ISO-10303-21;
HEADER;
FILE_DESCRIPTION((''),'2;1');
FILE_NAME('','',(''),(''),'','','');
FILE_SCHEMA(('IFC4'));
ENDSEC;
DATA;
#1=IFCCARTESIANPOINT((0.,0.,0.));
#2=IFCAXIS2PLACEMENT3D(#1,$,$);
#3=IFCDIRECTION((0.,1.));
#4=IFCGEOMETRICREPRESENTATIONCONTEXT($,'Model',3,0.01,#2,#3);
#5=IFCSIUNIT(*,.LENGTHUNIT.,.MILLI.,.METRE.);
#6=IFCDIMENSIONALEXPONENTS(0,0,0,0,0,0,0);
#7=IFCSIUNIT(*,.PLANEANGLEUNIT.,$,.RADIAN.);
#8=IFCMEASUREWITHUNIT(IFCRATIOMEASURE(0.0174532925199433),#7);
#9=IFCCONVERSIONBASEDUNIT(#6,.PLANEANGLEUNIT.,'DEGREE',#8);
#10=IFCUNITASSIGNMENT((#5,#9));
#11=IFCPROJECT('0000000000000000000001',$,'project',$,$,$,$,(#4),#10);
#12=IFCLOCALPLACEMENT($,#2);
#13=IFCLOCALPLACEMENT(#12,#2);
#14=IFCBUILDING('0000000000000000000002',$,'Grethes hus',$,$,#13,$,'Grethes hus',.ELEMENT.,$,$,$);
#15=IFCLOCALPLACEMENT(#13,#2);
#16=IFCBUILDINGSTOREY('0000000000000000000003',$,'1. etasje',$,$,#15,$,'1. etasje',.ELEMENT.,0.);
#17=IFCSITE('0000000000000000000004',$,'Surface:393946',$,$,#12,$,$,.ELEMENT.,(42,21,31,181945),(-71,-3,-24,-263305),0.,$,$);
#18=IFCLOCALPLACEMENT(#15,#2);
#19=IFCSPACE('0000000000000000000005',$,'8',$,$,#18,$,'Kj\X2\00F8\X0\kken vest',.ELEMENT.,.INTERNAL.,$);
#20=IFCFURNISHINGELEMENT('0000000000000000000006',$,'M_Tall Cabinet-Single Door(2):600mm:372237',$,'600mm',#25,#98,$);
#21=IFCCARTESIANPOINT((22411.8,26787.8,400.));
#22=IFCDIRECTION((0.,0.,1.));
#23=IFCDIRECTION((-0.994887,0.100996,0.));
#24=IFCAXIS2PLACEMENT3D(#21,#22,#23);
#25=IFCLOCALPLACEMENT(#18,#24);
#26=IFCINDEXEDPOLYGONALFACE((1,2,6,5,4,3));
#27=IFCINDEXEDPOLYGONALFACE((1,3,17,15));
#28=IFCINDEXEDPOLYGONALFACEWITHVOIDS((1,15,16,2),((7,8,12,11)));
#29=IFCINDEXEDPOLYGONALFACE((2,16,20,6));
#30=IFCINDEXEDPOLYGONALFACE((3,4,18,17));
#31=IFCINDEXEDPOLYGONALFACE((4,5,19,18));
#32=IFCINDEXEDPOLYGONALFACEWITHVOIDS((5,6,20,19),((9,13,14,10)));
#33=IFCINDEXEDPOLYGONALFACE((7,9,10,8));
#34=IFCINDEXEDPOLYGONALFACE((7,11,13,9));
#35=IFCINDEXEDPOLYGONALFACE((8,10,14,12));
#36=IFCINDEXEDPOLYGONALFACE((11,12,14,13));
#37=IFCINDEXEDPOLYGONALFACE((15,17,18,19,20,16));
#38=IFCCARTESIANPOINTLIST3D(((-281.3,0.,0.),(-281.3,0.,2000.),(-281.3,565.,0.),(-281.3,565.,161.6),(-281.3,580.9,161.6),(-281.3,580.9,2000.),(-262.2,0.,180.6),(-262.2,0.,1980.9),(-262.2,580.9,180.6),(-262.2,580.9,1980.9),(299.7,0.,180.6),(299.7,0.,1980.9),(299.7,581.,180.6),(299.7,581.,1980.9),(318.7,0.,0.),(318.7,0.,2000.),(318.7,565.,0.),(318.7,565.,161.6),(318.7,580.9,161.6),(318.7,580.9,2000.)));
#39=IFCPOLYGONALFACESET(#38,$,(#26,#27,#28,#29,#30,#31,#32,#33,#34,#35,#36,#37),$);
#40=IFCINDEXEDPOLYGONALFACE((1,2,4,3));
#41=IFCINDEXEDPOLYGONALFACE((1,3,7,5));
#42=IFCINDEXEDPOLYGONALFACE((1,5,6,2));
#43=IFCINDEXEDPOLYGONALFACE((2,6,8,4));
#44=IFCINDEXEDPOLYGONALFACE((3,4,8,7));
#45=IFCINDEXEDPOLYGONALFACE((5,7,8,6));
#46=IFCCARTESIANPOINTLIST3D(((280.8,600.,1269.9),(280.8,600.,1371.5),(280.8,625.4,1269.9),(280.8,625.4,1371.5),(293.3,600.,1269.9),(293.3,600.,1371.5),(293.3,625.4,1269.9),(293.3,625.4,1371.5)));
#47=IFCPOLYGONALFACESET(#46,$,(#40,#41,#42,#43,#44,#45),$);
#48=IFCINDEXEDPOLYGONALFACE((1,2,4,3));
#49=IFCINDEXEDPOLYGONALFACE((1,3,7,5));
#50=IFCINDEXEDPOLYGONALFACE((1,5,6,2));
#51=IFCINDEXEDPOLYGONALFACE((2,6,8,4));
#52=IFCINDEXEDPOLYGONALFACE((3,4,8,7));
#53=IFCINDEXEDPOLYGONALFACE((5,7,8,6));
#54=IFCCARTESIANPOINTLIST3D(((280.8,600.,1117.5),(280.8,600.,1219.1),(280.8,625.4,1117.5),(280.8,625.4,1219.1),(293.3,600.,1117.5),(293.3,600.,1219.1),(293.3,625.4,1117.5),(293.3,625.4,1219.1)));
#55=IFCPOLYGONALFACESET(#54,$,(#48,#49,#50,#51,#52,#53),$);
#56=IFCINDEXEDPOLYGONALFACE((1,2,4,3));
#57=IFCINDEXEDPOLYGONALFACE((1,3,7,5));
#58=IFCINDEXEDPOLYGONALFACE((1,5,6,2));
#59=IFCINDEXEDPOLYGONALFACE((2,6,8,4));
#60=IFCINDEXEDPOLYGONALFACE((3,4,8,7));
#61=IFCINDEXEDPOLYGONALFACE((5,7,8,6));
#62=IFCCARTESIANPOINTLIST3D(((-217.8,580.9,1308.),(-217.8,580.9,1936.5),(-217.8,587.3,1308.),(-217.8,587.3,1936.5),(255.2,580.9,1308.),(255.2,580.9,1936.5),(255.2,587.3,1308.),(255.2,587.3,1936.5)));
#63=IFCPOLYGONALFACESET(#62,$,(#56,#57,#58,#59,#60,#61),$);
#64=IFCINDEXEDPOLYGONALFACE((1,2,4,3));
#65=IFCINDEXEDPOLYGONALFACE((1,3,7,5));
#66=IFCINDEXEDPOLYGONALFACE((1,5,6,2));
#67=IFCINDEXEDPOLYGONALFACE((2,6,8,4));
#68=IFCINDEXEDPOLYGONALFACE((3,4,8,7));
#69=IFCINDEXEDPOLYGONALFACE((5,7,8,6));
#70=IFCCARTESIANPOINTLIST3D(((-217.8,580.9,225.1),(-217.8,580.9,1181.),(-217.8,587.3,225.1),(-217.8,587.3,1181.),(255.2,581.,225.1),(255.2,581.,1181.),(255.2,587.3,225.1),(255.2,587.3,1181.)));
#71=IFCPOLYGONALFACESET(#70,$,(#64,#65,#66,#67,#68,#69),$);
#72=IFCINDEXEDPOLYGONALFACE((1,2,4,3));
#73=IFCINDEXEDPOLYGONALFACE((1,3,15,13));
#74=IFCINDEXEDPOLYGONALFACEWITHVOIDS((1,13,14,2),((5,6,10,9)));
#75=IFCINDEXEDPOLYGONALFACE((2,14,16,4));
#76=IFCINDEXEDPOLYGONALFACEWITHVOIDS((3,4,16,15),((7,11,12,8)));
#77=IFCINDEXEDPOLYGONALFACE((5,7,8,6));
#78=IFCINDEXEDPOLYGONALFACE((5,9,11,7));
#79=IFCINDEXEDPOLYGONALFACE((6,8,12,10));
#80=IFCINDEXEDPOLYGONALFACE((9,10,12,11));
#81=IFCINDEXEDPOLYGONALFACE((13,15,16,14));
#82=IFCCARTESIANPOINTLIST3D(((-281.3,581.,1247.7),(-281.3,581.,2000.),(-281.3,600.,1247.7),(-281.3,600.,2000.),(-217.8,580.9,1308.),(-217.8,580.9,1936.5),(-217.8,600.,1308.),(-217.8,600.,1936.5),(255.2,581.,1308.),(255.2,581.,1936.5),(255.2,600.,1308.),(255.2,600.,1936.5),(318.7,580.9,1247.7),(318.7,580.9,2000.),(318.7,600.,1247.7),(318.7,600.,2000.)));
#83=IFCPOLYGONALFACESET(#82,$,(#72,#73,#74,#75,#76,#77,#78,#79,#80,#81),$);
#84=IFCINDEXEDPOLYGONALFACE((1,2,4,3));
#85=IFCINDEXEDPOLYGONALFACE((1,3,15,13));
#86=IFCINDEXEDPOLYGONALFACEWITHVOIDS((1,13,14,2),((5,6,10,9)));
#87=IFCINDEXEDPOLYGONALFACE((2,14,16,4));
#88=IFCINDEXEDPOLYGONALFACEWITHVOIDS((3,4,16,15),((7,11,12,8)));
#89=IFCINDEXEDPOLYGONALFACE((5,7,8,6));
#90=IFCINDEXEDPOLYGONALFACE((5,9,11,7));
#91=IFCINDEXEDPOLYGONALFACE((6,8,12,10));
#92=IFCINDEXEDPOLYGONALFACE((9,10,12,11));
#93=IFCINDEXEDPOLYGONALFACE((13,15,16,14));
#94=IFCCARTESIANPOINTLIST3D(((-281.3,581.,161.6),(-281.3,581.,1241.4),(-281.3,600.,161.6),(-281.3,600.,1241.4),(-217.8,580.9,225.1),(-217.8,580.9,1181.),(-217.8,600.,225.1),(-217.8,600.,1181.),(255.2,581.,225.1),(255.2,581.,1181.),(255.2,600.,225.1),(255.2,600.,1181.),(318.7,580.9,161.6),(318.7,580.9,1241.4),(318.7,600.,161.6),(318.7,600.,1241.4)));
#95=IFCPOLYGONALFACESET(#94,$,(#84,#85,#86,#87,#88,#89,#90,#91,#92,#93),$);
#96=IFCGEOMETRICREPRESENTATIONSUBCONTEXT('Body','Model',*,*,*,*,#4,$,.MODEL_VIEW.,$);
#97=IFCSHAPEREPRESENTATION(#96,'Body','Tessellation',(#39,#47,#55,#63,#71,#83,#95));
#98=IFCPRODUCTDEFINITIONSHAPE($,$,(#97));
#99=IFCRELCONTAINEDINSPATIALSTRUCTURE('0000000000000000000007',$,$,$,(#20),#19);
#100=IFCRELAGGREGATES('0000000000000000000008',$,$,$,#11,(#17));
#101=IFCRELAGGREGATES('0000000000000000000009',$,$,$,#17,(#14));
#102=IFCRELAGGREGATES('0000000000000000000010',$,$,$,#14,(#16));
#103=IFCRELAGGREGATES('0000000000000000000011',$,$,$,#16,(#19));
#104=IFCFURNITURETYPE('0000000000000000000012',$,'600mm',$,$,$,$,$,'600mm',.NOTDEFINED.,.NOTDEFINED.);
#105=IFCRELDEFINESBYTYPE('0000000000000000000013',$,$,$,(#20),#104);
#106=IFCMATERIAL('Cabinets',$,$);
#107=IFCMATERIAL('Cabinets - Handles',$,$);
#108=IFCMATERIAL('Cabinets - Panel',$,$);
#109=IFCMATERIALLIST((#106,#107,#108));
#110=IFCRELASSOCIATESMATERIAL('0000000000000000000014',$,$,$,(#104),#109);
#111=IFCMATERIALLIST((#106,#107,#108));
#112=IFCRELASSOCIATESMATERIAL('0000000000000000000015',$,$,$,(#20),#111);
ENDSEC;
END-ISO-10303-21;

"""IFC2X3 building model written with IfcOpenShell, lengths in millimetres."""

from ifc_helpers import new_model, entity, si_unit, converted_unit, direction, frame, frame_2d, origin, origin_2d_with_axis, place, context, subcontext, project, spatial, polyline, rectangle, outline, extrude, source, transform, mapped, material, material_list, type_object, type_shapes, element, save


model = new_model("IFC2X3")

# Units and contexts
model_context = context("Model", 3, precision=0.01, world=origin(), true_north=direction((0.0, 1.0)))
body_context = subcontext(model_context, "Body", "Model", "MODEL_VIEW")
ifc_project = project(units=[si_unit("LENGTHUNIT", "METRE", prefix="MILLI"), converted_unit("PLANEANGLEUNIT", "DEGREE", entity("IfcRatioMeasure", 0.0174532925199433), si_unit("PLANEANGLEUNIT", "RADIAN"), dimensions=[0, 0, 0, 0, 0, 0, 0])], contexts=[model_context])

# Site, building, storey
site_placement = place(None, origin())
site = spatial("IfcSite", under=ifc_project, at=site_placement, Name="Surface:393946", CompositionType="ELEMENT", RefLatitude=(42, 21, 31, 181945), RefLongitude=(-71, -3, -24, -263305), RefElevation=0.0)
building_placement = place(site_placement, origin())
building = spatial("IfcBuilding", under=site, at=building_placement, Name="Grethes hus", LongName="Grethes hus", CompositionType="ELEMENT")
storey_placement = place(building_placement, origin())
storey = spatial("IfcBuildingStorey", under=building, at=storey_placement, Name="1. etasje", LongName="1. etasje", CompositionType="ELEMENT", Elevation=0.0)

# Shared definitions
space_placement = place(storey_placement, origin())
space = spatial("IfcSpace", under=storey, at=space_placement, Name="8", LongName="Kjøkken vest", CompositionType="ELEMENT", InteriorOrExteriorSpace="INTERNAL")

# Furnishing element, opening
ifc_material_1 = material(Name="Cabinets")
ifc_material_2 = material(Name="Cabinets - Handles")
ifc_material_3 = material(Name="Cabinets - Panel")
ifc_material_list_1 = material_list([ifc_material_1, ifc_material_2, ifc_material_3])
ifc_material_list_2 = material_list([ifc_material_1, ifc_material_2, ifc_material_3])
furniture_type_1 = type_object("IfcFurnitureType", Name="600mm", ElementType="600mm", material=ifc_material_list_2)
shared_shape_1 = source(origin(), body_context, "Body", "SweptSolid", [
    extrude(outline(polyline([(-558.9, -199.0), (1279.5, -199.0), (1279.5, 382.0), (-720.5, 382.0), (-720.5, -183.0), (-558.9, -183.0), (-558.9, -199.0)])), frame((-281.3, 382.0, 720.5), z_axis=(1.0, 0.0, 0.0), x_axis=(0.0, 0.0, 1.0)), (0.0, 0.0, 1.0), 600.0),
    extrude(rectangle(XDim=12.5, YDim=25.4, at=frame_2d((0.0, 0.0), x_axis=(1.0, 0.0))), frame((287.1, 612.7, 1269.9), z_axis=(0.0, 0.0, 1.0), x_axis=(-1.0, 0.0, 0.0)), (0.0, 0.0, 1.0), 101.6),
    extrude(rectangle(XDim=12.5, YDim=25.4, at=frame_2d((0.0, 0.0), x_axis=(1.0, 0.0))), frame((287.1, 612.7, 1117.5), z_axis=(0.0, 0.0, 1.0), x_axis=(-1.0, 0.0, 0.0)), (0.0, 0.0, 1.0), 101.6),
    extrude(rectangle(XDim=473.0, YDim=6.3, at=origin_2d_with_axis()), frame((18.7, 584.1, 1308.0), z_axis=(0.0, 0.0, 1.0), x_axis=(-1.0, 0.0, 0.0)), (0.0, 0.0, 1.0), 628.5),
    extrude(rectangle(XDim=473.0, YDim=6.3, at=origin_2d_with_axis()), frame((18.7, 584.1, 225.1), z_axis=(0.0, 0.0, 1.0), x_axis=(-1.0, 0.0, 0.0)), (0.0, 0.0, 1.0), 956.0),
    extrude(outline(polyline([(-376.1, -300.0), (376.1, -300.0), (376.1, 300.0), (-376.1, 300.0), (-376.1, -300.0)]), holes=[polyline([(-312.6, -236.5), (-312.6, 236.5), (315.8, 236.5), (315.8, -236.5), (-312.6, -236.5)])]), frame((18.7, 580.9, 1623.9), z_axis=(0.0, 1.0, 0.0), x_axis=(0.0, 0.0, -1.0)), (0.0, 0.0, 1.0), 19.1),
    extrude(outline(polyline([(-300.0, -539.9), (300.0, -539.9), (300.0, 539.9), (-300.0, 539.9), (-300.0, -539.9)]), holes=[polyline([(-236.5, 479.6), (236.5, 479.6), (236.5, -476.4), (-236.5, -476.4), (-236.5, 479.6)])]), frame((18.7, 580.9, 701.5), z_axis=(0.0, 1.0, 0.0), x_axis=(-1.0, 0.0, 0.0)), (0.0, 0.0, 1.0), 19.1),
    extrude(rectangle(XDim=561.9, YDim=19.1, at=origin_2d_with_axis()), frame((18.7, 9.5, 180.6), z_axis=(0.0, 0.0, 1.0), x_axis=(-1.0, 0.0, 0.0)), (0.0, 0.0, 1.0), 1800.3),
])
type_shapes(furniture_type_1, [shared_shape_1])
furnishing_1_placement = place(space_placement, frame((22411.8, 26787.8, 400.0), z_axis=(0.0, 0.0, 1.0), x_axis=(-0.994887, 0.100996, 0.0)))
furnishing_1 = element("IfcFurnishingElement", 1, at=furnishing_1_placement, inside=space, type_object=furniture_type_1, material=ifc_material_list_1, Name="M_Tall Cabinet-Single Door(2):600mm:372237", ObjectType="600mm", context=body_context, shape_type="MappedRepresentation", body=[
    mapped(shared_shape_1, transform((0.0, 0.0, 0.0), scale=1.0)),
])
opening_1_placement = place(storey_placement, frame((22411.8, 26787.8, 400.0), z_axis=(0.0, 0.0, 1.0), x_axis=(0.9796, -0.200959, 0.0)))
element("IfcOpeningElement", 2, at=opening_1_placement, cuts=furnishing_1, ObjectType="Opening", context=body_context, shape_type="SweptSolid", body=[
    extrude(rectangle(XDim=1800.3, YDim=561.9, at=frame_2d((0.0, 0.0), x_axis=(1.0, 0.0))), frame((-18.6, -1.9, 1080.8), z_axis=(0.100996, -0.994887, 0.0), x_axis=(0.0, 0.0, -1.0)), (0.0, 0.0, 1.0), 580.9),
])

save(model, "model.ifc")
